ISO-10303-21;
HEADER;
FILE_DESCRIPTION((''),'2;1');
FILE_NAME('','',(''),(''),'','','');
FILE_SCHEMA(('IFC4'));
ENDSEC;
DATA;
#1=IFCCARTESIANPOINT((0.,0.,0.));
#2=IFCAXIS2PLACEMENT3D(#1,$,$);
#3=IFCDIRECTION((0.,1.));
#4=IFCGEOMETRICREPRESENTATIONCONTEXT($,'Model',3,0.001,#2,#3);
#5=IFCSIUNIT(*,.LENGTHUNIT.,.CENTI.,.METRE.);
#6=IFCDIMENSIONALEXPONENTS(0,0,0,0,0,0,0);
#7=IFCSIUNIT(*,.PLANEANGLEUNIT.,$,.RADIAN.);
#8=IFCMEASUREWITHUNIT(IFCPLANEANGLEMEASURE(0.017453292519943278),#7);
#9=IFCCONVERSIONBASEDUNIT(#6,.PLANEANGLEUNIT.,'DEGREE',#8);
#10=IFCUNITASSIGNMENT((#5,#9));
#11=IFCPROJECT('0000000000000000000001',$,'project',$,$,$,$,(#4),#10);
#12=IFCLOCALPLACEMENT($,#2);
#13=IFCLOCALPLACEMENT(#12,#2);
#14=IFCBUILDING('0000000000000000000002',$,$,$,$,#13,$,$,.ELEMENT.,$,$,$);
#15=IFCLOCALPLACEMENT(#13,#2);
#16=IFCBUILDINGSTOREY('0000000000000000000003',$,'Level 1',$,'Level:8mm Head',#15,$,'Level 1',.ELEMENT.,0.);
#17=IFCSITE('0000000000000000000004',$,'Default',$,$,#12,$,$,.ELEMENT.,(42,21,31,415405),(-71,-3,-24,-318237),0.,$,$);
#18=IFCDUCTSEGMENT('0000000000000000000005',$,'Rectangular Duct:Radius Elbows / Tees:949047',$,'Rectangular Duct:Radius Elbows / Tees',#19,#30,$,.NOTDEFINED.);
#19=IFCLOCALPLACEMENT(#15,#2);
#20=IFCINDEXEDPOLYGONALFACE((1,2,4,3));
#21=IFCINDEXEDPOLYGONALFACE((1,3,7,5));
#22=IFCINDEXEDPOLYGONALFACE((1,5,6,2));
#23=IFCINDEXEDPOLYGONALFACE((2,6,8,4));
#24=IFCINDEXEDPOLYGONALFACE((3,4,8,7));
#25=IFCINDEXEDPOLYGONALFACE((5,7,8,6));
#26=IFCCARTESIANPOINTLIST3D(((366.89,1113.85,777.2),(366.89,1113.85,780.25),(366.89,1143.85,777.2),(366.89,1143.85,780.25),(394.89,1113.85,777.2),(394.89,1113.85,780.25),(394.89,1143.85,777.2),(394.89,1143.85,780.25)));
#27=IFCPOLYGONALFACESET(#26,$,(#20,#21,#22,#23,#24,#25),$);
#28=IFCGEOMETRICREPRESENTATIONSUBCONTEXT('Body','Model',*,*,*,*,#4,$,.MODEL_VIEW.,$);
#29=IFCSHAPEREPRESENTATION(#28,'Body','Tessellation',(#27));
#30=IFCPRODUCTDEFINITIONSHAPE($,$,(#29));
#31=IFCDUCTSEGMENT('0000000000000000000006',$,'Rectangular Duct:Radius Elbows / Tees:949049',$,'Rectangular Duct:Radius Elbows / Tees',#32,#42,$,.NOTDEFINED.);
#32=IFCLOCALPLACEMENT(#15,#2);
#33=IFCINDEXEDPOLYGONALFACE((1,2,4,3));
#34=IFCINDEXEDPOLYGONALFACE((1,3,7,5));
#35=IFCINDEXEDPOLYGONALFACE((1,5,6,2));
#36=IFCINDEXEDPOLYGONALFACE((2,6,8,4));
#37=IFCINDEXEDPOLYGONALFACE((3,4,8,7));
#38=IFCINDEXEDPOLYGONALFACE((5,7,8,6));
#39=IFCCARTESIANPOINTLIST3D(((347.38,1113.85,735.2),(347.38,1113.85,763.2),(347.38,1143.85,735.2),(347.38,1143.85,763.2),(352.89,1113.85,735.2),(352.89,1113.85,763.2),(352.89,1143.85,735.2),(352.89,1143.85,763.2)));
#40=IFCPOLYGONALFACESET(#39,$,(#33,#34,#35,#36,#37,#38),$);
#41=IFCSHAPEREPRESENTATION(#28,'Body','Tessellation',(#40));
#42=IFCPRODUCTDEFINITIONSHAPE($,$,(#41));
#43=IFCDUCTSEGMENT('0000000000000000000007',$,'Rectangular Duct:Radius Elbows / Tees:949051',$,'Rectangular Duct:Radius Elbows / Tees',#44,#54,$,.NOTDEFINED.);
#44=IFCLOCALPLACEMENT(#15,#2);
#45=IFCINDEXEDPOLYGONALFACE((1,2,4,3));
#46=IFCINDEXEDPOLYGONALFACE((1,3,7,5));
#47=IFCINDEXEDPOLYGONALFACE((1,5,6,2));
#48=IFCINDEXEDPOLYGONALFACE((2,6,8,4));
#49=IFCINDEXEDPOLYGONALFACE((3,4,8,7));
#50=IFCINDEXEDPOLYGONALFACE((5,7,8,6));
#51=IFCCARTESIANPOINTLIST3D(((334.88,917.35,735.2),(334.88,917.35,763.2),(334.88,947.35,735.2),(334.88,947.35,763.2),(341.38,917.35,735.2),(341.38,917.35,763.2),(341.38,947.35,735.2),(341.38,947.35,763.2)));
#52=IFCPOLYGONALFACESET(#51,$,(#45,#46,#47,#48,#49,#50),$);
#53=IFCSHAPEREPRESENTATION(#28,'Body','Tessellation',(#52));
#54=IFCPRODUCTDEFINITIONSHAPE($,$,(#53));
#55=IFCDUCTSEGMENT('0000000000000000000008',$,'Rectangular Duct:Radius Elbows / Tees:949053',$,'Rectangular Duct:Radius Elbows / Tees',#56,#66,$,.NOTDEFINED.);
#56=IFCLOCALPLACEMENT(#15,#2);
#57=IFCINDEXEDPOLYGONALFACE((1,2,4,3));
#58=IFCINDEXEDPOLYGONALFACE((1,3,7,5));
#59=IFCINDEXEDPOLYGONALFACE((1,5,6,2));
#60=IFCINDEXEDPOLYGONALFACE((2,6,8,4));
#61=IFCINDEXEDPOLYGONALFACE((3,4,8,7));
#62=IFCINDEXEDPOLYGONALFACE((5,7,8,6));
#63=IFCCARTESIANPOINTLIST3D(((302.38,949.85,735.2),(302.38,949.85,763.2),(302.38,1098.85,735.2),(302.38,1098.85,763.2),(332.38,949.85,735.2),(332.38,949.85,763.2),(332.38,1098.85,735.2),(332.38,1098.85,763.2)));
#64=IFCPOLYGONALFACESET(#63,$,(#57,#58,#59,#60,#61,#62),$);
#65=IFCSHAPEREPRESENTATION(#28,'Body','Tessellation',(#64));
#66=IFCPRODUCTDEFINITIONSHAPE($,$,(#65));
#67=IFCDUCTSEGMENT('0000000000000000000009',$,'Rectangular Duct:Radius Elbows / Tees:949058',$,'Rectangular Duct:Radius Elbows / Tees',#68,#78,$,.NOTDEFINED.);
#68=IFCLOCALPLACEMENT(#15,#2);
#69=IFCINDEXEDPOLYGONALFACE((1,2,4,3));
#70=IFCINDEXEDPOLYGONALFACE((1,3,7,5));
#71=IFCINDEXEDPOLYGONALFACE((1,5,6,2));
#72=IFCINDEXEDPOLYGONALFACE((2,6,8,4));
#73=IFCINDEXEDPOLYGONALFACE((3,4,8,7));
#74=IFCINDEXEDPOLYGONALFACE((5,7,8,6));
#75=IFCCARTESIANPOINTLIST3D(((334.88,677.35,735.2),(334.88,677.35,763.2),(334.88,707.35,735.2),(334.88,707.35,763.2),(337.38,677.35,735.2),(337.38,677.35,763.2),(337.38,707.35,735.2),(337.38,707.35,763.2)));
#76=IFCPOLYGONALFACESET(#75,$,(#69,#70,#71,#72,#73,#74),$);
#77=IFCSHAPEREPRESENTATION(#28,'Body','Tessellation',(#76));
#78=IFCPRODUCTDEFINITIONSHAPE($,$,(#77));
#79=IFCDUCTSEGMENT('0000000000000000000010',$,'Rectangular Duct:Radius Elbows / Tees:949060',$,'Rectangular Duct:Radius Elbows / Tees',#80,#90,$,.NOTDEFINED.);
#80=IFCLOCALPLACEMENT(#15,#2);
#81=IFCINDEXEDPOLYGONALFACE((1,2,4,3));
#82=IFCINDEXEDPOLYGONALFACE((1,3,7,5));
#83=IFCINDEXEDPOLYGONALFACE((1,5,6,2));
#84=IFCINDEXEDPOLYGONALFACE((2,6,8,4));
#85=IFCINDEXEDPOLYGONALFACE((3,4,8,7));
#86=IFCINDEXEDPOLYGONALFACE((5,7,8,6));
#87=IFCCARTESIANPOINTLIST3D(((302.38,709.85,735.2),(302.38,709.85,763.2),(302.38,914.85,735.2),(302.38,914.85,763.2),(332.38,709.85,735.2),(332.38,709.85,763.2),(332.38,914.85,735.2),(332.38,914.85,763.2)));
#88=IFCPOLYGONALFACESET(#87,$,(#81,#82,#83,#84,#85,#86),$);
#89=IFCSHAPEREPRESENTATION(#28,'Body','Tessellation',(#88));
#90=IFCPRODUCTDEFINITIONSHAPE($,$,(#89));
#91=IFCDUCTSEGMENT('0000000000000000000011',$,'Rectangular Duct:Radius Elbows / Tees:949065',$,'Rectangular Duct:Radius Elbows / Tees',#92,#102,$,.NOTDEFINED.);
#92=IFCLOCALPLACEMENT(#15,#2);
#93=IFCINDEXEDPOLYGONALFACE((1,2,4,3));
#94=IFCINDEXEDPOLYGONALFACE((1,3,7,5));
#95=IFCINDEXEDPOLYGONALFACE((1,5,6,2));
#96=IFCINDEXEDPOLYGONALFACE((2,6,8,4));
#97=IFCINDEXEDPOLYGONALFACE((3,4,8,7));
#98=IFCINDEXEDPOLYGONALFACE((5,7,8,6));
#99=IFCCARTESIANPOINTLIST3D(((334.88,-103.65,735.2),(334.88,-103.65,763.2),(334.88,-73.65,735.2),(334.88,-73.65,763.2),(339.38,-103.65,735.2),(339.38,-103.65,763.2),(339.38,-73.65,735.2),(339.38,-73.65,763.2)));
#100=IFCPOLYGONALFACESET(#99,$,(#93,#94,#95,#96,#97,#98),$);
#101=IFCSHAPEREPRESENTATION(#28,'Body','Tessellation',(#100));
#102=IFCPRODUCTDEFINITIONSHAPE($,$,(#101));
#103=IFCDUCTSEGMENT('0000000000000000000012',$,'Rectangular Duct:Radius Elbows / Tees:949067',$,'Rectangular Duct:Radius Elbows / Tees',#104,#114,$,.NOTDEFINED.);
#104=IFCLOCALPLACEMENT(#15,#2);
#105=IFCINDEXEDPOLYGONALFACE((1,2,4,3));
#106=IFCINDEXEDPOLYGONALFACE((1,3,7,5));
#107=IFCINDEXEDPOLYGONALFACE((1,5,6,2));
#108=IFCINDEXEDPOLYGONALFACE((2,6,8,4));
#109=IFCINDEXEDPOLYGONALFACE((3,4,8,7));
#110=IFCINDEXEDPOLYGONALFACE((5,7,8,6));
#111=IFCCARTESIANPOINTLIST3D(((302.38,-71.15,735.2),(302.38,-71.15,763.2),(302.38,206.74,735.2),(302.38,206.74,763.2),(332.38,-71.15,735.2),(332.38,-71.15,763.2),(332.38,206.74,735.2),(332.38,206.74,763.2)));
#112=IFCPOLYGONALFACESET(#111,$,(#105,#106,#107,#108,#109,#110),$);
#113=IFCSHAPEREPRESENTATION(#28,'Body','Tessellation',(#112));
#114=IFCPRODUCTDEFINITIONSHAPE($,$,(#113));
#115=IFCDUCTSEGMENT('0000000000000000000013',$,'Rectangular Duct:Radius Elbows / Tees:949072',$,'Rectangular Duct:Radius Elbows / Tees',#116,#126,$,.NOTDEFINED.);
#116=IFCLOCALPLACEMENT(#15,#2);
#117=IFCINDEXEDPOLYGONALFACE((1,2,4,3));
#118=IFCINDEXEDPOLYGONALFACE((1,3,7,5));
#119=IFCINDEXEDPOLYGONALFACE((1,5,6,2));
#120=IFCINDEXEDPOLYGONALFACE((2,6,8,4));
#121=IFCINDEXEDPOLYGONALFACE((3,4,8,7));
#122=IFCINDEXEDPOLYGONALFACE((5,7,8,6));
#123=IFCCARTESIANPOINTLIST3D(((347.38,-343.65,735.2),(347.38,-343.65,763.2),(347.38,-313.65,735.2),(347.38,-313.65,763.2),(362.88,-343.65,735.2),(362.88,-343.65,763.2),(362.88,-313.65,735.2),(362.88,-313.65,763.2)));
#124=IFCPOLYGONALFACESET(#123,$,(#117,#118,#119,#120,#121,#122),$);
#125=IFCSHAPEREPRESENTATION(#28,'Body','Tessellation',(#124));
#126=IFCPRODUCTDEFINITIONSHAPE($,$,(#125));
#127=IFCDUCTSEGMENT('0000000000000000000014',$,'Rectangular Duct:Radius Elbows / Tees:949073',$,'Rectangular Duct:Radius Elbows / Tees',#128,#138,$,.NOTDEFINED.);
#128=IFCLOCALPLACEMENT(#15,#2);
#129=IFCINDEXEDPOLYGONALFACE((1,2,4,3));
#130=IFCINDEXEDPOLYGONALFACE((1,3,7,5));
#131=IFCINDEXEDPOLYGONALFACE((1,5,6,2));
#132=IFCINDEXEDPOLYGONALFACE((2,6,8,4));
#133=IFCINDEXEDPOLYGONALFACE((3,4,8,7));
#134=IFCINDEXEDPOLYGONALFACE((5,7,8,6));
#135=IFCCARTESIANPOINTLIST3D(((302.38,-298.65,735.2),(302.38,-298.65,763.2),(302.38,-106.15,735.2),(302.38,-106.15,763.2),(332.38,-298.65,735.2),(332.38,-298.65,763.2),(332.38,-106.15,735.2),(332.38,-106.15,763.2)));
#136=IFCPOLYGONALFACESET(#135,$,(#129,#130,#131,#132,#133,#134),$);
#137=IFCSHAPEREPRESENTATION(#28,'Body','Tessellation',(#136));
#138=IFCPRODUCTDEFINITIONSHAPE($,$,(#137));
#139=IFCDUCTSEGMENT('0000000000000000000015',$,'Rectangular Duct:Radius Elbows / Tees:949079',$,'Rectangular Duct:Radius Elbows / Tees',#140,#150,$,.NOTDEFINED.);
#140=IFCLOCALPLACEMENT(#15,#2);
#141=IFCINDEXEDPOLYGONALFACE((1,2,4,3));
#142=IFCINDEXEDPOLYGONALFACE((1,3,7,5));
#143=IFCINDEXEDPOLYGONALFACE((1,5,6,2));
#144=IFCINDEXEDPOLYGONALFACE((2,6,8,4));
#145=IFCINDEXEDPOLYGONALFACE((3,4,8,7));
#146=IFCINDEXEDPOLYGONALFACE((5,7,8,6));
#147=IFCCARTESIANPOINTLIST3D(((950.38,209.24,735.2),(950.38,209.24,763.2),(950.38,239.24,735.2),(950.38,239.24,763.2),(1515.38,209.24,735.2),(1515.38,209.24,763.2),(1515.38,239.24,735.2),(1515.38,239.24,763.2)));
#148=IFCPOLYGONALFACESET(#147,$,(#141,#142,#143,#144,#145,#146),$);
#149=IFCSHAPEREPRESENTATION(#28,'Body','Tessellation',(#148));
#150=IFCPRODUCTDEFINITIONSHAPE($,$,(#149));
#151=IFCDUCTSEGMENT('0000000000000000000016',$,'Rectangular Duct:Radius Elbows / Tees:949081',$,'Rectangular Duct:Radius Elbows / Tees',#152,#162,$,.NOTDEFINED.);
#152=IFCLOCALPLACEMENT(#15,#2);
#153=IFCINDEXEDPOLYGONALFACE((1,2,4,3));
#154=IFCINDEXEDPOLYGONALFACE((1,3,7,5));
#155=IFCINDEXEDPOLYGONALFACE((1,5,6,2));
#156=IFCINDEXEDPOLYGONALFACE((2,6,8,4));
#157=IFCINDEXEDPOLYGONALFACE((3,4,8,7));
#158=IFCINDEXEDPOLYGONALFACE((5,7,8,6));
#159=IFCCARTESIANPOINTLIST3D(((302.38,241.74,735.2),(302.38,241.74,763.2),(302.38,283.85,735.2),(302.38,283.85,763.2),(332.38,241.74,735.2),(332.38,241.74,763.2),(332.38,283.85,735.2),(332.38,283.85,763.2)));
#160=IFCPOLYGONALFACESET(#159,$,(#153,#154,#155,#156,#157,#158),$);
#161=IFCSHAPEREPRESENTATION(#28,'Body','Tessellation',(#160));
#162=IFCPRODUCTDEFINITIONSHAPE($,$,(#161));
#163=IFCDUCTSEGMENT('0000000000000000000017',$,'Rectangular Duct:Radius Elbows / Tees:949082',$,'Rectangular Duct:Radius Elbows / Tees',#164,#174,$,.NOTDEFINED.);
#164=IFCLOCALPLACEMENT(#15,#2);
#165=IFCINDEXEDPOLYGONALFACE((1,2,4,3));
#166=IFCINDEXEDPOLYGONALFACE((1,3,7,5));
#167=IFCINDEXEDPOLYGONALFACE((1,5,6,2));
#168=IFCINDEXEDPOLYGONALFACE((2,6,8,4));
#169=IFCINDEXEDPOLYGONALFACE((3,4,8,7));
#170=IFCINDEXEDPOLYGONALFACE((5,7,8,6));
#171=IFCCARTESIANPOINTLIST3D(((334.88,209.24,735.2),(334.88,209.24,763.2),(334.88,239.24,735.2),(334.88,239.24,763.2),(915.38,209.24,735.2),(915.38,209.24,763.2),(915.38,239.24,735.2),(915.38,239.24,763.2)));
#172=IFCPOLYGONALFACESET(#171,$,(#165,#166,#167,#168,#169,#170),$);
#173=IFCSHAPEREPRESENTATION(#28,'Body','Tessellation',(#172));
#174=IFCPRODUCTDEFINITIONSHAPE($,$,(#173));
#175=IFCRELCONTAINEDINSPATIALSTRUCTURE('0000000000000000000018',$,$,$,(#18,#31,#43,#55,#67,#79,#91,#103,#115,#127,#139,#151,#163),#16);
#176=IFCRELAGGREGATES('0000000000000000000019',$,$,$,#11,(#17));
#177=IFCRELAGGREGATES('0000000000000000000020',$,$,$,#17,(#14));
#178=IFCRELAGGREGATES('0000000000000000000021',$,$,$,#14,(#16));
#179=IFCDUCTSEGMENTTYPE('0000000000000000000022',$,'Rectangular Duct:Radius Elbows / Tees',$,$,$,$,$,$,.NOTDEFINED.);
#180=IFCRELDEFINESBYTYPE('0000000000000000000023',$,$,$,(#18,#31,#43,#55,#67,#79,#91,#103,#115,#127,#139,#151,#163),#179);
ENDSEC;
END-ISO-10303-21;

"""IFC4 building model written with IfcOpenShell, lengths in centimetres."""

from ifc_helpers import new_model, entity, si_unit, converted_unit, direction, frame, origin, place, context, subcontext, project, spatial, indexed_curve, outline, extrude, type_object, element, save


model = new_model("IFC4")

# Units and contexts
model_context = context("Model", 3, precision=0.001, world=origin(), true_north=direction((0.0, 1.0)))
body_context = subcontext(model_context, "Body", "Model", "MODEL_VIEW")
ifc_project = project(units=[si_unit("LENGTHUNIT", "METRE", prefix="CENTI"), converted_unit("PLANEANGLEUNIT", "DEGREE", entity("IfcPlaneAngleMeasure", 0.017453292519943278), si_unit("PLANEANGLEUNIT", "RADIAN"), dimensions=[0, 0, 0, 0, 0, 0, 0])], contexts=[model_context])

# Site, building, storey
site_placement = place(None, origin())
site = spatial("IfcSite", under=ifc_project, at=site_placement, Name="Default", CompositionType="ELEMENT", RefLatitude=(42, 21, 31, 415405), RefLongitude=(-71, -3, -24, -318237), RefElevation=0.0)
building_placement = place(site_placement, origin())
building = spatial("IfcBuilding", under=site, at=building_placement, CompositionType="ELEMENT")
storey_placement = place(building_placement, origin())
storey = spatial("IfcBuildingStorey", under=building, at=storey_placement, Name="Level 1", ObjectType="Level:8mm Head", LongName="Level 1", CompositionType="ELEMENT", Elevation=0.0)

# Duct segments
duct_segment_type = type_object("IfcDuctSegmentType", Name="Rectangular Duct:Radius Elbows / Tees", PredefinedType="NOTDEFINED")
duct_segment_1_placement = place(storey_placement, origin())
element("IfcDuctSegment", 1, at=duct_segment_1_placement, inside=storey, type_object=duct_segment_type, Name="Rectangular Duct:Radius Elbows / Tees:949047", ObjectType="Rectangular Duct:Radius Elbows / Tees", PredefinedType="NOTDEFINED", context=body_context, shape_type="SweptSolid", body=[
    extrude(outline(indexed_curve([(-15.0, -14.0), (15.0, -14.0), (15.0, 14.0), (-15.0, 14.0), (-15.0, -14.0)], self_intersect=False)), frame((380.89, 1128.85, 777.2), z_axis=(0.0, 0.0, 1.0), x_axis=(0.0, 1.0, 0.0)), (0.0, 0.0, 1.0), 3.05),
])
duct_segment_2_placement = place(storey_placement, origin())
element("IfcDuctSegment", 2, at=duct_segment_2_placement, inside=storey, type_object=duct_segment_type, Name="Rectangular Duct:Radius Elbows / Tees:949049", ObjectType="Rectangular Duct:Radius Elbows / Tees", PredefinedType="NOTDEFINED", context=body_context, shape_type="SweptSolid", body=[
    extrude(outline(indexed_curve([(-2.76, -15.0), (2.76, -15.0), (2.76, 15.0), (-2.76, 15.0), (-2.76, -15.0)], self_intersect=False)), frame((350.13, 1128.85, 735.2), z_axis=(0.0, 0.0, 1.0), x_axis=(-1.0, 0.0, 0.0)), (0.0, 0.0, 1.0), 28.0),
])
duct_segment_3_placement = place(storey_placement, origin())
element("IfcDuctSegment", 3, at=duct_segment_3_placement, inside=storey, type_object=duct_segment_type, Name="Rectangular Duct:Radius Elbows / Tees:949051", ObjectType="Rectangular Duct:Radius Elbows / Tees", PredefinedType="NOTDEFINED", context=body_context, shape_type="SweptSolid", body=[
    extrude(outline(indexed_curve([(-3.25, -15.0), (3.25, -15.0), (3.25, 15.0), (-3.25, 15.0), (-3.25, -15.0)], self_intersect=False)), frame((338.13, 932.35, 735.2)), (0.0, 0.0, 1.0), 28.0),
])
duct_segment_4_placement = place(storey_placement, origin())
element("IfcDuctSegment", 4, at=duct_segment_4_placement, inside=storey, type_object=duct_segment_type, Name="Rectangular Duct:Radius Elbows / Tees:949053", ObjectType="Rectangular Duct:Radius Elbows / Tees", PredefinedType="NOTDEFINED", context=body_context, shape_type="SweptSolid", body=[
    extrude(outline(indexed_curve([(-74.5, -15.0), (74.5, -15.0), (74.5, 15.0), (-74.5, 15.0), (-74.5, -15.0)], self_intersect=False)), frame((317.38, 1024.35, 735.2), z_axis=(0.0, 0.0, 1.0), x_axis=(0.0, -1.0, 0.0)), (0.0, 0.0, 1.0), 28.0),
])
duct_segment_5_placement = place(storey_placement, origin())
element("IfcDuctSegment", 5, at=duct_segment_5_placement, inside=storey, type_object=duct_segment_type, Name="Rectangular Duct:Radius Elbows / Tees:949058", ObjectType="Rectangular Duct:Radius Elbows / Tees", PredefinedType="NOTDEFINED", context=body_context, shape_type="SweptSolid", body=[
    extrude(outline(indexed_curve([(-1.25, -15.0), (1.25, -15.0), (1.25, 15.0), (-1.25, 15.0), (-1.25, -15.0)], self_intersect=False)), frame((336.13, 692.35, 735.2)), (0.0, 0.0, 1.0), 28.0),
])
duct_segment_6_placement = place(storey_placement, origin())
element("IfcDuctSegment", 6, at=duct_segment_6_placement, inside=storey, type_object=duct_segment_type, Name="Rectangular Duct:Radius Elbows / Tees:949060", ObjectType="Rectangular Duct:Radius Elbows / Tees", PredefinedType="NOTDEFINED", context=body_context, shape_type="SweptSolid", body=[
    extrude(outline(indexed_curve([(-102.5, -15.0), (102.5, -15.0), (102.5, 15.0), (-102.5, 15.0), (-102.5, -15.0)], self_intersect=False)), frame((317.38, 812.35, 735.2), z_axis=(0.0, 0.0, 1.0), x_axis=(0.0, -1.0, 0.0)), (0.0, 0.0, 1.0), 28.0),
])
duct_segment_7_placement = place(storey_placement, origin())
element("IfcDuctSegment", 7, at=duct_segment_7_placement, inside=storey, type_object=duct_segment_type, Name="Rectangular Duct:Radius Elbows / Tees:949065", ObjectType="Rectangular Duct:Radius Elbows / Tees", PredefinedType="NOTDEFINED", context=body_context, shape_type="SweptSolid", body=[
    extrude(outline(indexed_curve([(-2.25, -15.0), (2.25, -15.0), (2.25, 15.0), (-2.25, 15.0), (-2.25, -15.0)], self_intersect=False)), frame((337.13, -88.65, 735.2)), (0.0, 0.0, 1.0), 28.0),
])
duct_segment_8_placement = place(storey_placement, origin())
element("IfcDuctSegment", 8, at=duct_segment_8_placement, inside=storey, type_object=duct_segment_type, Name="Rectangular Duct:Radius Elbows / Tees:949067", ObjectType="Rectangular Duct:Radius Elbows / Tees", PredefinedType="NOTDEFINED", context=body_context, shape_type="SweptSolid", body=[
    extrude(outline(indexed_curve([(-138.95, -15.0), (138.95, -15.0), (138.95, 15.0), (-138.95, 15.0), (-138.95, -15.0)], self_intersect=False)), frame((317.38, 67.79, 735.2), z_axis=(0.0, 0.0, 1.0), x_axis=(0.0, -1.0, 0.0)), (0.0, 0.0, 1.0), 28.0),
])
duct_segment_9_placement = place(storey_placement, origin())
element("IfcDuctSegment", 9, at=duct_segment_9_placement, inside=storey, type_object=duct_segment_type, Name="Rectangular Duct:Radius Elbows / Tees:949072", ObjectType="Rectangular Duct:Radius Elbows / Tees", PredefinedType="NOTDEFINED", context=body_context, shape_type="SweptSolid", body=[
    extrude(outline(indexed_curve([(-7.75, -15.0), (7.75, -15.0), (7.75, 15.0), (-7.75, 15.0), (-7.75, -15.0)], self_intersect=False)), frame((355.13, -328.65, 735.2)), (0.0, 0.0, 1.0), 28.0),
])
duct_segment_10_placement = place(storey_placement, origin())
element("IfcDuctSegment", 10, at=duct_segment_10_placement, inside=storey, type_object=duct_segment_type, Name="Rectangular Duct:Radius Elbows / Tees:949073", ObjectType="Rectangular Duct:Radius Elbows / Tees", PredefinedType="NOTDEFINED", context=body_context, shape_type="SweptSolid", body=[
    extrude(outline(indexed_curve([(-96.25, -15.0), (96.25, -15.0), (96.25, 15.0), (-96.25, 15.0), (-96.25, -15.0)], self_intersect=False)), frame((317.38, -202.4, 735.2), z_axis=(0.0, 0.0, 1.0), x_axis=(0.0, -1.0, 0.0)), (0.0, 0.0, 1.0), 28.0),
])
duct_segment_11_placement = place(storey_placement, origin())
element("IfcDuctSegment", 11, at=duct_segment_11_placement, inside=storey, type_object=duct_segment_type, Name="Rectangular Duct:Radius Elbows / Tees:949079", ObjectType="Rectangular Duct:Radius Elbows / Tees", PredefinedType="NOTDEFINED", context=body_context, shape_type="SweptSolid", body=[
    extrude(outline(indexed_curve([(-282.5, -15.0), (282.5, -15.0), (282.5, 15.0), (-282.5, 15.0), (-282.5, -15.0)], self_intersect=False)), frame((1232.88, 224.24, 735.2)), (0.0, 0.0, 1.0), 28.0),
])
duct_segment_12_placement = place(storey_placement, origin())
element("IfcDuctSegment", 12, at=duct_segment_12_placement, inside=storey, type_object=duct_segment_type, Name="Rectangular Duct:Radius Elbows / Tees:949081", ObjectType="Rectangular Duct:Radius Elbows / Tees", PredefinedType="NOTDEFINED", context=body_context, shape_type="SweptSolid", body=[
    extrude(outline(indexed_curve([(-21.05, -15.0), (21.05, -15.0), (21.05, 15.0), (-21.05, 15.0), (-21.05, -15.0)], self_intersect=False)), frame((317.38, 262.79, 735.2), z_axis=(0.0, 0.0, 1.0), x_axis=(0.0, -1.0, 0.0)), (0.0, 0.0, 1.0), 28.0),
])
duct_segment_13_placement = place(storey_placement, origin())
element("IfcDuctSegment", 13, at=duct_segment_13_placement, inside=storey, type_object=duct_segment_type, Name="Rectangular Duct:Radius Elbows / Tees:949082", ObjectType="Rectangular Duct:Radius Elbows / Tees", PredefinedType="NOTDEFINED", context=body_context, shape_type="SweptSolid", body=[
    extrude(outline(indexed_curve([(-290.25, -15.0), (290.25, -15.0), (290.25, 15.0), (-290.25, 15.0), (-290.25, -15.0)], self_intersect=False)), frame((625.13, 224.24, 735.2)), (0.0, 0.0, 1.0), 28.0),
])

save(model, "model.ifc")
